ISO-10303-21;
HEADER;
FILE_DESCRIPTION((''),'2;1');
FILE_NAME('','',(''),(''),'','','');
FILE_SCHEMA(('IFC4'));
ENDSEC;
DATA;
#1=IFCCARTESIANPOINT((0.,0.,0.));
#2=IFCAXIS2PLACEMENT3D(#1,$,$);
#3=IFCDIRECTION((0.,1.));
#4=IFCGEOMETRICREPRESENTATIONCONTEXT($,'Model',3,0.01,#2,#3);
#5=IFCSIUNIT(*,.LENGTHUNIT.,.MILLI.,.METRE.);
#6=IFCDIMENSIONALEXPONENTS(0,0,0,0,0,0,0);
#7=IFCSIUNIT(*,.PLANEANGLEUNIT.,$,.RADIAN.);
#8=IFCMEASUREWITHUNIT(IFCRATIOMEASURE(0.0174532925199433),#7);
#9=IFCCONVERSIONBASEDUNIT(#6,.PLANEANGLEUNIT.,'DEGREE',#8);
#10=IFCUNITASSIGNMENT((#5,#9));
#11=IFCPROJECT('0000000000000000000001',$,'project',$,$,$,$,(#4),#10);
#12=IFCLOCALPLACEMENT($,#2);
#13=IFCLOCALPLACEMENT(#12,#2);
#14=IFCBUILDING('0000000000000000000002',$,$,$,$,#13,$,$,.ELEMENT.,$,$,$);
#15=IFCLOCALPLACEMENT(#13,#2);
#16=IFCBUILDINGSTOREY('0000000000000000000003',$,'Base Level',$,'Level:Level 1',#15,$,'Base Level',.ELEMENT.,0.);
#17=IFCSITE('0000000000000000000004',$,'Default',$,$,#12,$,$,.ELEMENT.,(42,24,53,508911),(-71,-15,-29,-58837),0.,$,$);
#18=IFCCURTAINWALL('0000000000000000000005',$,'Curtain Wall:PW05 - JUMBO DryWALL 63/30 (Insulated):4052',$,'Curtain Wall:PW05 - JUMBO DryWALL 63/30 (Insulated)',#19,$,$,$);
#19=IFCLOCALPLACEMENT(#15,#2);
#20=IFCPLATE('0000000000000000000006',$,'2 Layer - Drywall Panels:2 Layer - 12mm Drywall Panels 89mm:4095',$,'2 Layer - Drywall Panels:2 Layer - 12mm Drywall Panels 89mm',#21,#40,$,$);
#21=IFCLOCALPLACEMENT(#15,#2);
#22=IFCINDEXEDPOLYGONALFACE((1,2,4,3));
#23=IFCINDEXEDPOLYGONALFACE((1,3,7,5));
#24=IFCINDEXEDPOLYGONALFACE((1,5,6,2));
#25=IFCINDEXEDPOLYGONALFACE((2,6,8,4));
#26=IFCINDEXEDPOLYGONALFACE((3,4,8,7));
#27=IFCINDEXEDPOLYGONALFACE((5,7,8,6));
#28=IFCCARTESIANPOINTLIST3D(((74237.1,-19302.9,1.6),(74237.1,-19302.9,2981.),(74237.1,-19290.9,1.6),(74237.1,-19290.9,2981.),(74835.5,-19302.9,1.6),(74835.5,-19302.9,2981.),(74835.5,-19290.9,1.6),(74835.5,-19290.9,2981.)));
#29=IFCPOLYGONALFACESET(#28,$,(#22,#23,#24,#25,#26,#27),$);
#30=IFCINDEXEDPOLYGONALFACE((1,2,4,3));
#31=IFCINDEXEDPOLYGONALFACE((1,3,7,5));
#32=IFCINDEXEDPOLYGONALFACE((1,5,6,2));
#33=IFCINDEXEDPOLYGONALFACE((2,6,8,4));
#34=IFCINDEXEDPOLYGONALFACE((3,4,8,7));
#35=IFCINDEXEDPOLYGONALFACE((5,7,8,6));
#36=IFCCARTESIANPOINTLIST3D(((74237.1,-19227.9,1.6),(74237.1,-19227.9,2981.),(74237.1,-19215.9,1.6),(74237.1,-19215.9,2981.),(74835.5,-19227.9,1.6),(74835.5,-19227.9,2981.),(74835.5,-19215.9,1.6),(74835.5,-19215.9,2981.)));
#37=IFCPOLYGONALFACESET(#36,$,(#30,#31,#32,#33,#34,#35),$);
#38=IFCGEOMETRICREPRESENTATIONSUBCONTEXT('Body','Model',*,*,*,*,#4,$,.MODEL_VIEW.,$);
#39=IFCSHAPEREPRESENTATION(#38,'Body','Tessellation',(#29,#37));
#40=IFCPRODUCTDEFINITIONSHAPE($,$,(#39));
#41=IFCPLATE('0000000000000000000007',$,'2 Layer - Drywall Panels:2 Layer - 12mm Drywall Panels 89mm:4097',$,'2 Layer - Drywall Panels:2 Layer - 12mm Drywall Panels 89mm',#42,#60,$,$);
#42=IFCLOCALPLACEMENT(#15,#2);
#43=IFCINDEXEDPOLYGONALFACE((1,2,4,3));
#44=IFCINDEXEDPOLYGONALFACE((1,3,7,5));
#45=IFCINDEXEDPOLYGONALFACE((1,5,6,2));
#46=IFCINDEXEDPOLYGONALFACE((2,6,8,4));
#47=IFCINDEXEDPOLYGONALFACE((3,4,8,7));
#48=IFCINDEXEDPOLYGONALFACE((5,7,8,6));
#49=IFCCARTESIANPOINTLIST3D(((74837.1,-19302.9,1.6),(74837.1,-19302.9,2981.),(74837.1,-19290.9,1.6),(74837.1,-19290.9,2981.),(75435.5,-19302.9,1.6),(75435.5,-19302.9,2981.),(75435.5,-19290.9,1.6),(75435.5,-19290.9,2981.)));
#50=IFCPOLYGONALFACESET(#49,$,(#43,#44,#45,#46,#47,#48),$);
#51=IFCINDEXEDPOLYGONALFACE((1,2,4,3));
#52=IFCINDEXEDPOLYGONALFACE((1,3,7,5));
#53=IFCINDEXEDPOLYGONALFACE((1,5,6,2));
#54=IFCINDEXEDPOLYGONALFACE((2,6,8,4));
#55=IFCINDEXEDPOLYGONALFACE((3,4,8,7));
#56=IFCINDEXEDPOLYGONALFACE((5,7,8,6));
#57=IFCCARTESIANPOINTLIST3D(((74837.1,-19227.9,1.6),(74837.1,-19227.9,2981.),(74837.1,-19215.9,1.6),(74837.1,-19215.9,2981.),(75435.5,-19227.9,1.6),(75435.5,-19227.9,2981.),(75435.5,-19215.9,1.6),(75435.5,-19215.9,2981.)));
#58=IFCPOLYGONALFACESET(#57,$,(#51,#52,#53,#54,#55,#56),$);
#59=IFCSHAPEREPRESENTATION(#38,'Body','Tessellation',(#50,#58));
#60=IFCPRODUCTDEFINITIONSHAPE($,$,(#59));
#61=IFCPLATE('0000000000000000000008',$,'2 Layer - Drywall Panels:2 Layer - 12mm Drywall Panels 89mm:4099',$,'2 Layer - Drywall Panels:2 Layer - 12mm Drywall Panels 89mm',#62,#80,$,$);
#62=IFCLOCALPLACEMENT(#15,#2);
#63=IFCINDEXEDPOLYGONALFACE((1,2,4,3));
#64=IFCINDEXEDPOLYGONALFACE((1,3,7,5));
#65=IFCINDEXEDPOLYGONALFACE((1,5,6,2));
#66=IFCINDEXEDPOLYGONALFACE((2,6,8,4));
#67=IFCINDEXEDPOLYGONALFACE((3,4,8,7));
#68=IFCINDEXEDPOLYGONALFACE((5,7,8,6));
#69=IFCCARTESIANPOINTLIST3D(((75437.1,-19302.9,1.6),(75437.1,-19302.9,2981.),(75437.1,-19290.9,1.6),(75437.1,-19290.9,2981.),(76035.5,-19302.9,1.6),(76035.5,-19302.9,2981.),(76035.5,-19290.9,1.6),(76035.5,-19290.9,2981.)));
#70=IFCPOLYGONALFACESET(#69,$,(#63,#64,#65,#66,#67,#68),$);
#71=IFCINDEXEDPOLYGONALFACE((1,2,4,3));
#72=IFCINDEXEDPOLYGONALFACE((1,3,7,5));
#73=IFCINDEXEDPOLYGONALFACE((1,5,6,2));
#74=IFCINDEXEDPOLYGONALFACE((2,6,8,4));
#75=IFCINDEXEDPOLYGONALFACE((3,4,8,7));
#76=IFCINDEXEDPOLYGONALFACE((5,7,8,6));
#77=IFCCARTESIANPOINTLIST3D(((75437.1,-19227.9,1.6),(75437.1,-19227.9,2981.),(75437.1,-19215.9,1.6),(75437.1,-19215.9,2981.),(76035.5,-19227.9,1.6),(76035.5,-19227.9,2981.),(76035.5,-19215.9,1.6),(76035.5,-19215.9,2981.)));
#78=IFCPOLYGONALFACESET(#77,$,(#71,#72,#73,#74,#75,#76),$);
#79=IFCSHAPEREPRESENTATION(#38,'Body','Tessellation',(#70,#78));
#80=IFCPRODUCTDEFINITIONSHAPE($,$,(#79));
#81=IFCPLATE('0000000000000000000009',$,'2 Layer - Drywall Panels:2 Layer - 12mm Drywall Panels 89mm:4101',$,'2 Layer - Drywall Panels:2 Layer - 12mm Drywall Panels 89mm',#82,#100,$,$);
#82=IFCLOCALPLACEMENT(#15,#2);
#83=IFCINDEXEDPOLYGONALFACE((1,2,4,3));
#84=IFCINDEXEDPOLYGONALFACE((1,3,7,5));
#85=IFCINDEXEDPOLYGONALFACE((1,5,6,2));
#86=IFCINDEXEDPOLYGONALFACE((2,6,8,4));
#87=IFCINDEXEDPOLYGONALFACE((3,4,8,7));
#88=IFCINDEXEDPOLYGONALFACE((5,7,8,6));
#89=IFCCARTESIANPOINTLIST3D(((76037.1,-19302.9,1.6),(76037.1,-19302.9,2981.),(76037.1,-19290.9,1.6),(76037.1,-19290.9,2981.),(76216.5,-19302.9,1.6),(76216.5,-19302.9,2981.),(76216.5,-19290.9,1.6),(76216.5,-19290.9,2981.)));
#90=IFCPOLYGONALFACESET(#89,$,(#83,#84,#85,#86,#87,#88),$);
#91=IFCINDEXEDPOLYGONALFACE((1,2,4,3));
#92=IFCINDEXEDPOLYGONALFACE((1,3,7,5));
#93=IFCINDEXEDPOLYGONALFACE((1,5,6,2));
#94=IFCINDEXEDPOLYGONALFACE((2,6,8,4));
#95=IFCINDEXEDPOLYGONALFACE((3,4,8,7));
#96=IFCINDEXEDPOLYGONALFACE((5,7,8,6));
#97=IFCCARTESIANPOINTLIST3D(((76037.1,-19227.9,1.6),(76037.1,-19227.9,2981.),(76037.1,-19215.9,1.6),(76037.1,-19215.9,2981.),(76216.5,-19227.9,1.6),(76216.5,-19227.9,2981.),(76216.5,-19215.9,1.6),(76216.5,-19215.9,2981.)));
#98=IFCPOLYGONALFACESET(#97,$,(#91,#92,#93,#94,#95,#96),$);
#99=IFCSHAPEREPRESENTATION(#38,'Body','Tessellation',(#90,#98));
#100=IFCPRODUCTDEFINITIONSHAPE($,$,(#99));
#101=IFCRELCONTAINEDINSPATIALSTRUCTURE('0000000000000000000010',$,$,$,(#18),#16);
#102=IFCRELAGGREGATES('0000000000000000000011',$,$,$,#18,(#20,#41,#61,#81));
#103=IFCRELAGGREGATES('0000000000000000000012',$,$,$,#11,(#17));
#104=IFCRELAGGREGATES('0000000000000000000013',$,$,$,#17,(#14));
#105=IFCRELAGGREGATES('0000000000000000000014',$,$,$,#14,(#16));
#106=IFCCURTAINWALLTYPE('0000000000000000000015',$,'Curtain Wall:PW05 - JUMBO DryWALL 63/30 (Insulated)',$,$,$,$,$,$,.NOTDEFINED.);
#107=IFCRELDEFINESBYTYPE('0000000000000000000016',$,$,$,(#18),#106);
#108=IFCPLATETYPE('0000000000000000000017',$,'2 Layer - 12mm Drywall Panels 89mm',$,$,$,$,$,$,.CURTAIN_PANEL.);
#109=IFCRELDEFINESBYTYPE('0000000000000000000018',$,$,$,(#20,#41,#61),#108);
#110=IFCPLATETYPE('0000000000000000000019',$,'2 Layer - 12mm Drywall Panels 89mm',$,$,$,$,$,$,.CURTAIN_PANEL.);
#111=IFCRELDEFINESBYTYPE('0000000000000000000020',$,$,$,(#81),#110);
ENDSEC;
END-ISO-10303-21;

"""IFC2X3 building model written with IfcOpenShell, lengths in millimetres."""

from ifc_helpers import new_model, entity, si_unit, converted_unit, direction, frame, frame_2d, origin, place, context, subcontext, project, spatial, rectangle, extrude, source, transform, mapped, type_object, type_shapes, element, aggregate, save


model = new_model("IFC2X3")

# Units and contexts
model_context = context("Model", 3, precision=0.01, world=origin(), true_north=direction((0.0, 1.0)))
body_context = subcontext(model_context, "Body", "Model", "MODEL_VIEW")
ifc_project = project(units=[si_unit("LENGTHUNIT", "METRE", prefix="MILLI"), converted_unit("PLANEANGLEUNIT", "DEGREE", entity("IfcRatioMeasure", 0.0174532925199433), si_unit("PLANEANGLEUNIT", "RADIAN"), dimensions=[0, 0, 0, 0, 0, 0, 0])], contexts=[model_context])

# Site, building, storey
site_placement = place(None, origin())
site = spatial("IfcSite", under=ifc_project, at=site_placement, Name="Default", CompositionType="ELEMENT", RefLatitude=(42, 24, 53, 508911), RefLongitude=(-71, -15, -29, -58837), RefElevation=0.0)
building_placement = place(site_placement, origin())
building = spatial("IfcBuilding", under=site, at=building_placement, CompositionType="ELEMENT")
storey_placement = place(building_placement, origin())
storey = spatial("IfcBuildingStorey", under=building, at=storey_placement, Name="Base Level", ObjectType="Level:Level 1", LongName="Base Level", CompositionType="ELEMENT", Elevation=0.0)

# Curtain wall, plates
curtain_wall_type = type_object("IfcCurtainWallType", Name="Curtain Wall:PW05 - JUMBO DryWALL 63/30 (Insulated)", PredefinedType="NOTDEFINED")
curtain_wall_placement = place(building_placement, origin())
curtain_wall = element("IfcCurtainWall", 1, at=curtain_wall_placement, inside=storey, type_object=curtain_wall_type, Name="Curtain Wall:PW05 - JUMBO DryWALL 63/30 (Insulated):4052", ObjectType="Curtain Wall:PW05 - JUMBO DryWALL 63/30 (Insulated)")
plate_type_1 = type_object("IfcPlateType", Name="2 Layer - 12mm Drywall Panels 89mm", PredefinedType="CURTAIN_PANEL")
shared_shape_1 = source(origin(), body_context, "Body", "SweptSolid", [
    extrude(rectangle(XDim=598.4, YDim=12.0, at=frame_2d((0.0, 0.0), x_axis=(1.0, 0.0))), frame((0.0, -37.5, 0.0), z_axis=(0.0, 0.0, 1.0), x_axis=(-1.0, 0.0, 0.0)), (0.0, 0.0, 1.0), 2979.4),
    extrude(rectangle(XDim=12.0, YDim=598.4, at=frame_2d((0.0, 0.0), x_axis=(1.0, 0.0))), frame((0.0, 37.5, 0.0), z_axis=(0.0, 0.0, 1.0), x_axis=(0.0, 1.0, 0.0)), (0.0, 0.0, 1.0), 2979.4),
])
type_shapes(plate_type_1, [shared_shape_1])
plate_1_placement = place(curtain_wall_placement, frame((74536.3, -19259.4, 1.6)))
plate_1 = element("IfcPlate", 2, at=plate_1_placement, type_object=plate_type_1, Name="2 Layer - Drywall Panels:2 Layer - 12mm Drywall Panels 89mm:4095", ObjectType="2 Layer - Drywall Panels:2 Layer - 12mm Drywall Panels 89mm", context=body_context, shape_type="MappedRepresentation", body=[
    mapped(shared_shape_1, transform((0.0, 0.0, 0.0), scale=1.0)),
])
plate_2_placement = place(curtain_wall_placement, frame((75136.3, -19259.4, 1.6)))
plate_2 = element("IfcPlate", 3, at=plate_2_placement, type_object=plate_type_1, Name="2 Layer - Drywall Panels:2 Layer - 12mm Drywall Panels 89mm:4097", ObjectType="2 Layer - Drywall Panels:2 Layer - 12mm Drywall Panels 89mm", context=body_context, shape_type="MappedRepresentation", body=[
    mapped(shared_shape_1, transform((0.0, 0.0, 0.0), scale=1.0)),
])
plate_3_placement = place(curtain_wall_placement, frame((75736.3, -19259.4, 1.6)))
plate_3 = element("IfcPlate", 4, at=plate_3_placement, type_object=plate_type_1, Name="2 Layer - Drywall Panels:2 Layer - 12mm Drywall Panels 89mm:4099", ObjectType="2 Layer - Drywall Panels:2 Layer - 12mm Drywall Panels 89mm", context=body_context, shape_type="MappedRepresentation", body=[
    mapped(shared_shape_1, transform((0.0, 0.0, 0.0), scale=1.0)),
])
plate_type_2 = type_object("IfcPlateType", Name="2 Layer - 12mm Drywall Panels 89mm", PredefinedType="CURTAIN_PANEL")
shared_shape_2 = source(origin(), body_context, "Body", "SweptSolid", [
    extrude(rectangle(XDim=179.4, YDim=12.0, at=frame_2d((0.0, 0.0), x_axis=(1.0, 0.0))), frame((0.0, -37.5, 0.0), z_axis=(0.0, 0.0, 1.0), x_axis=(-1.0, 0.0, 0.0)), (0.0, 0.0, 1.0), 2979.4),
    extrude(rectangle(XDim=12.0, YDim=179.4, at=frame_2d((0.0, 0.0), x_axis=(1.0, 0.0))), frame((0.0, 37.5, 0.0), z_axis=(0.0, 0.0, 1.0), x_axis=(0.0, 1.0, 0.0)), (0.0, 0.0, 1.0), 2979.4),
])
type_shapes(plate_type_2, [shared_shape_2])
plate_4_placement = place(curtain_wall_placement, frame((76126.8, -19259.4, 1.6)))
plate_4 = element("IfcPlate", 5, at=plate_4_placement, type_object=plate_type_2, Name="2 Layer - Drywall Panels:2 Layer - 12mm Drywall Panels 89mm:4101", ObjectType="2 Layer - Drywall Panels:2 Layer - 12mm Drywall Panels 89mm", context=body_context, shape_type="MappedRepresentation", body=[
    mapped(shared_shape_2, transform((0.0, 0.0, 0.0), scale=1.0)),
])
aggregate(curtain_wall, [plate_1, plate_2, plate_3, plate_4])

save(model, "model.ifc")
